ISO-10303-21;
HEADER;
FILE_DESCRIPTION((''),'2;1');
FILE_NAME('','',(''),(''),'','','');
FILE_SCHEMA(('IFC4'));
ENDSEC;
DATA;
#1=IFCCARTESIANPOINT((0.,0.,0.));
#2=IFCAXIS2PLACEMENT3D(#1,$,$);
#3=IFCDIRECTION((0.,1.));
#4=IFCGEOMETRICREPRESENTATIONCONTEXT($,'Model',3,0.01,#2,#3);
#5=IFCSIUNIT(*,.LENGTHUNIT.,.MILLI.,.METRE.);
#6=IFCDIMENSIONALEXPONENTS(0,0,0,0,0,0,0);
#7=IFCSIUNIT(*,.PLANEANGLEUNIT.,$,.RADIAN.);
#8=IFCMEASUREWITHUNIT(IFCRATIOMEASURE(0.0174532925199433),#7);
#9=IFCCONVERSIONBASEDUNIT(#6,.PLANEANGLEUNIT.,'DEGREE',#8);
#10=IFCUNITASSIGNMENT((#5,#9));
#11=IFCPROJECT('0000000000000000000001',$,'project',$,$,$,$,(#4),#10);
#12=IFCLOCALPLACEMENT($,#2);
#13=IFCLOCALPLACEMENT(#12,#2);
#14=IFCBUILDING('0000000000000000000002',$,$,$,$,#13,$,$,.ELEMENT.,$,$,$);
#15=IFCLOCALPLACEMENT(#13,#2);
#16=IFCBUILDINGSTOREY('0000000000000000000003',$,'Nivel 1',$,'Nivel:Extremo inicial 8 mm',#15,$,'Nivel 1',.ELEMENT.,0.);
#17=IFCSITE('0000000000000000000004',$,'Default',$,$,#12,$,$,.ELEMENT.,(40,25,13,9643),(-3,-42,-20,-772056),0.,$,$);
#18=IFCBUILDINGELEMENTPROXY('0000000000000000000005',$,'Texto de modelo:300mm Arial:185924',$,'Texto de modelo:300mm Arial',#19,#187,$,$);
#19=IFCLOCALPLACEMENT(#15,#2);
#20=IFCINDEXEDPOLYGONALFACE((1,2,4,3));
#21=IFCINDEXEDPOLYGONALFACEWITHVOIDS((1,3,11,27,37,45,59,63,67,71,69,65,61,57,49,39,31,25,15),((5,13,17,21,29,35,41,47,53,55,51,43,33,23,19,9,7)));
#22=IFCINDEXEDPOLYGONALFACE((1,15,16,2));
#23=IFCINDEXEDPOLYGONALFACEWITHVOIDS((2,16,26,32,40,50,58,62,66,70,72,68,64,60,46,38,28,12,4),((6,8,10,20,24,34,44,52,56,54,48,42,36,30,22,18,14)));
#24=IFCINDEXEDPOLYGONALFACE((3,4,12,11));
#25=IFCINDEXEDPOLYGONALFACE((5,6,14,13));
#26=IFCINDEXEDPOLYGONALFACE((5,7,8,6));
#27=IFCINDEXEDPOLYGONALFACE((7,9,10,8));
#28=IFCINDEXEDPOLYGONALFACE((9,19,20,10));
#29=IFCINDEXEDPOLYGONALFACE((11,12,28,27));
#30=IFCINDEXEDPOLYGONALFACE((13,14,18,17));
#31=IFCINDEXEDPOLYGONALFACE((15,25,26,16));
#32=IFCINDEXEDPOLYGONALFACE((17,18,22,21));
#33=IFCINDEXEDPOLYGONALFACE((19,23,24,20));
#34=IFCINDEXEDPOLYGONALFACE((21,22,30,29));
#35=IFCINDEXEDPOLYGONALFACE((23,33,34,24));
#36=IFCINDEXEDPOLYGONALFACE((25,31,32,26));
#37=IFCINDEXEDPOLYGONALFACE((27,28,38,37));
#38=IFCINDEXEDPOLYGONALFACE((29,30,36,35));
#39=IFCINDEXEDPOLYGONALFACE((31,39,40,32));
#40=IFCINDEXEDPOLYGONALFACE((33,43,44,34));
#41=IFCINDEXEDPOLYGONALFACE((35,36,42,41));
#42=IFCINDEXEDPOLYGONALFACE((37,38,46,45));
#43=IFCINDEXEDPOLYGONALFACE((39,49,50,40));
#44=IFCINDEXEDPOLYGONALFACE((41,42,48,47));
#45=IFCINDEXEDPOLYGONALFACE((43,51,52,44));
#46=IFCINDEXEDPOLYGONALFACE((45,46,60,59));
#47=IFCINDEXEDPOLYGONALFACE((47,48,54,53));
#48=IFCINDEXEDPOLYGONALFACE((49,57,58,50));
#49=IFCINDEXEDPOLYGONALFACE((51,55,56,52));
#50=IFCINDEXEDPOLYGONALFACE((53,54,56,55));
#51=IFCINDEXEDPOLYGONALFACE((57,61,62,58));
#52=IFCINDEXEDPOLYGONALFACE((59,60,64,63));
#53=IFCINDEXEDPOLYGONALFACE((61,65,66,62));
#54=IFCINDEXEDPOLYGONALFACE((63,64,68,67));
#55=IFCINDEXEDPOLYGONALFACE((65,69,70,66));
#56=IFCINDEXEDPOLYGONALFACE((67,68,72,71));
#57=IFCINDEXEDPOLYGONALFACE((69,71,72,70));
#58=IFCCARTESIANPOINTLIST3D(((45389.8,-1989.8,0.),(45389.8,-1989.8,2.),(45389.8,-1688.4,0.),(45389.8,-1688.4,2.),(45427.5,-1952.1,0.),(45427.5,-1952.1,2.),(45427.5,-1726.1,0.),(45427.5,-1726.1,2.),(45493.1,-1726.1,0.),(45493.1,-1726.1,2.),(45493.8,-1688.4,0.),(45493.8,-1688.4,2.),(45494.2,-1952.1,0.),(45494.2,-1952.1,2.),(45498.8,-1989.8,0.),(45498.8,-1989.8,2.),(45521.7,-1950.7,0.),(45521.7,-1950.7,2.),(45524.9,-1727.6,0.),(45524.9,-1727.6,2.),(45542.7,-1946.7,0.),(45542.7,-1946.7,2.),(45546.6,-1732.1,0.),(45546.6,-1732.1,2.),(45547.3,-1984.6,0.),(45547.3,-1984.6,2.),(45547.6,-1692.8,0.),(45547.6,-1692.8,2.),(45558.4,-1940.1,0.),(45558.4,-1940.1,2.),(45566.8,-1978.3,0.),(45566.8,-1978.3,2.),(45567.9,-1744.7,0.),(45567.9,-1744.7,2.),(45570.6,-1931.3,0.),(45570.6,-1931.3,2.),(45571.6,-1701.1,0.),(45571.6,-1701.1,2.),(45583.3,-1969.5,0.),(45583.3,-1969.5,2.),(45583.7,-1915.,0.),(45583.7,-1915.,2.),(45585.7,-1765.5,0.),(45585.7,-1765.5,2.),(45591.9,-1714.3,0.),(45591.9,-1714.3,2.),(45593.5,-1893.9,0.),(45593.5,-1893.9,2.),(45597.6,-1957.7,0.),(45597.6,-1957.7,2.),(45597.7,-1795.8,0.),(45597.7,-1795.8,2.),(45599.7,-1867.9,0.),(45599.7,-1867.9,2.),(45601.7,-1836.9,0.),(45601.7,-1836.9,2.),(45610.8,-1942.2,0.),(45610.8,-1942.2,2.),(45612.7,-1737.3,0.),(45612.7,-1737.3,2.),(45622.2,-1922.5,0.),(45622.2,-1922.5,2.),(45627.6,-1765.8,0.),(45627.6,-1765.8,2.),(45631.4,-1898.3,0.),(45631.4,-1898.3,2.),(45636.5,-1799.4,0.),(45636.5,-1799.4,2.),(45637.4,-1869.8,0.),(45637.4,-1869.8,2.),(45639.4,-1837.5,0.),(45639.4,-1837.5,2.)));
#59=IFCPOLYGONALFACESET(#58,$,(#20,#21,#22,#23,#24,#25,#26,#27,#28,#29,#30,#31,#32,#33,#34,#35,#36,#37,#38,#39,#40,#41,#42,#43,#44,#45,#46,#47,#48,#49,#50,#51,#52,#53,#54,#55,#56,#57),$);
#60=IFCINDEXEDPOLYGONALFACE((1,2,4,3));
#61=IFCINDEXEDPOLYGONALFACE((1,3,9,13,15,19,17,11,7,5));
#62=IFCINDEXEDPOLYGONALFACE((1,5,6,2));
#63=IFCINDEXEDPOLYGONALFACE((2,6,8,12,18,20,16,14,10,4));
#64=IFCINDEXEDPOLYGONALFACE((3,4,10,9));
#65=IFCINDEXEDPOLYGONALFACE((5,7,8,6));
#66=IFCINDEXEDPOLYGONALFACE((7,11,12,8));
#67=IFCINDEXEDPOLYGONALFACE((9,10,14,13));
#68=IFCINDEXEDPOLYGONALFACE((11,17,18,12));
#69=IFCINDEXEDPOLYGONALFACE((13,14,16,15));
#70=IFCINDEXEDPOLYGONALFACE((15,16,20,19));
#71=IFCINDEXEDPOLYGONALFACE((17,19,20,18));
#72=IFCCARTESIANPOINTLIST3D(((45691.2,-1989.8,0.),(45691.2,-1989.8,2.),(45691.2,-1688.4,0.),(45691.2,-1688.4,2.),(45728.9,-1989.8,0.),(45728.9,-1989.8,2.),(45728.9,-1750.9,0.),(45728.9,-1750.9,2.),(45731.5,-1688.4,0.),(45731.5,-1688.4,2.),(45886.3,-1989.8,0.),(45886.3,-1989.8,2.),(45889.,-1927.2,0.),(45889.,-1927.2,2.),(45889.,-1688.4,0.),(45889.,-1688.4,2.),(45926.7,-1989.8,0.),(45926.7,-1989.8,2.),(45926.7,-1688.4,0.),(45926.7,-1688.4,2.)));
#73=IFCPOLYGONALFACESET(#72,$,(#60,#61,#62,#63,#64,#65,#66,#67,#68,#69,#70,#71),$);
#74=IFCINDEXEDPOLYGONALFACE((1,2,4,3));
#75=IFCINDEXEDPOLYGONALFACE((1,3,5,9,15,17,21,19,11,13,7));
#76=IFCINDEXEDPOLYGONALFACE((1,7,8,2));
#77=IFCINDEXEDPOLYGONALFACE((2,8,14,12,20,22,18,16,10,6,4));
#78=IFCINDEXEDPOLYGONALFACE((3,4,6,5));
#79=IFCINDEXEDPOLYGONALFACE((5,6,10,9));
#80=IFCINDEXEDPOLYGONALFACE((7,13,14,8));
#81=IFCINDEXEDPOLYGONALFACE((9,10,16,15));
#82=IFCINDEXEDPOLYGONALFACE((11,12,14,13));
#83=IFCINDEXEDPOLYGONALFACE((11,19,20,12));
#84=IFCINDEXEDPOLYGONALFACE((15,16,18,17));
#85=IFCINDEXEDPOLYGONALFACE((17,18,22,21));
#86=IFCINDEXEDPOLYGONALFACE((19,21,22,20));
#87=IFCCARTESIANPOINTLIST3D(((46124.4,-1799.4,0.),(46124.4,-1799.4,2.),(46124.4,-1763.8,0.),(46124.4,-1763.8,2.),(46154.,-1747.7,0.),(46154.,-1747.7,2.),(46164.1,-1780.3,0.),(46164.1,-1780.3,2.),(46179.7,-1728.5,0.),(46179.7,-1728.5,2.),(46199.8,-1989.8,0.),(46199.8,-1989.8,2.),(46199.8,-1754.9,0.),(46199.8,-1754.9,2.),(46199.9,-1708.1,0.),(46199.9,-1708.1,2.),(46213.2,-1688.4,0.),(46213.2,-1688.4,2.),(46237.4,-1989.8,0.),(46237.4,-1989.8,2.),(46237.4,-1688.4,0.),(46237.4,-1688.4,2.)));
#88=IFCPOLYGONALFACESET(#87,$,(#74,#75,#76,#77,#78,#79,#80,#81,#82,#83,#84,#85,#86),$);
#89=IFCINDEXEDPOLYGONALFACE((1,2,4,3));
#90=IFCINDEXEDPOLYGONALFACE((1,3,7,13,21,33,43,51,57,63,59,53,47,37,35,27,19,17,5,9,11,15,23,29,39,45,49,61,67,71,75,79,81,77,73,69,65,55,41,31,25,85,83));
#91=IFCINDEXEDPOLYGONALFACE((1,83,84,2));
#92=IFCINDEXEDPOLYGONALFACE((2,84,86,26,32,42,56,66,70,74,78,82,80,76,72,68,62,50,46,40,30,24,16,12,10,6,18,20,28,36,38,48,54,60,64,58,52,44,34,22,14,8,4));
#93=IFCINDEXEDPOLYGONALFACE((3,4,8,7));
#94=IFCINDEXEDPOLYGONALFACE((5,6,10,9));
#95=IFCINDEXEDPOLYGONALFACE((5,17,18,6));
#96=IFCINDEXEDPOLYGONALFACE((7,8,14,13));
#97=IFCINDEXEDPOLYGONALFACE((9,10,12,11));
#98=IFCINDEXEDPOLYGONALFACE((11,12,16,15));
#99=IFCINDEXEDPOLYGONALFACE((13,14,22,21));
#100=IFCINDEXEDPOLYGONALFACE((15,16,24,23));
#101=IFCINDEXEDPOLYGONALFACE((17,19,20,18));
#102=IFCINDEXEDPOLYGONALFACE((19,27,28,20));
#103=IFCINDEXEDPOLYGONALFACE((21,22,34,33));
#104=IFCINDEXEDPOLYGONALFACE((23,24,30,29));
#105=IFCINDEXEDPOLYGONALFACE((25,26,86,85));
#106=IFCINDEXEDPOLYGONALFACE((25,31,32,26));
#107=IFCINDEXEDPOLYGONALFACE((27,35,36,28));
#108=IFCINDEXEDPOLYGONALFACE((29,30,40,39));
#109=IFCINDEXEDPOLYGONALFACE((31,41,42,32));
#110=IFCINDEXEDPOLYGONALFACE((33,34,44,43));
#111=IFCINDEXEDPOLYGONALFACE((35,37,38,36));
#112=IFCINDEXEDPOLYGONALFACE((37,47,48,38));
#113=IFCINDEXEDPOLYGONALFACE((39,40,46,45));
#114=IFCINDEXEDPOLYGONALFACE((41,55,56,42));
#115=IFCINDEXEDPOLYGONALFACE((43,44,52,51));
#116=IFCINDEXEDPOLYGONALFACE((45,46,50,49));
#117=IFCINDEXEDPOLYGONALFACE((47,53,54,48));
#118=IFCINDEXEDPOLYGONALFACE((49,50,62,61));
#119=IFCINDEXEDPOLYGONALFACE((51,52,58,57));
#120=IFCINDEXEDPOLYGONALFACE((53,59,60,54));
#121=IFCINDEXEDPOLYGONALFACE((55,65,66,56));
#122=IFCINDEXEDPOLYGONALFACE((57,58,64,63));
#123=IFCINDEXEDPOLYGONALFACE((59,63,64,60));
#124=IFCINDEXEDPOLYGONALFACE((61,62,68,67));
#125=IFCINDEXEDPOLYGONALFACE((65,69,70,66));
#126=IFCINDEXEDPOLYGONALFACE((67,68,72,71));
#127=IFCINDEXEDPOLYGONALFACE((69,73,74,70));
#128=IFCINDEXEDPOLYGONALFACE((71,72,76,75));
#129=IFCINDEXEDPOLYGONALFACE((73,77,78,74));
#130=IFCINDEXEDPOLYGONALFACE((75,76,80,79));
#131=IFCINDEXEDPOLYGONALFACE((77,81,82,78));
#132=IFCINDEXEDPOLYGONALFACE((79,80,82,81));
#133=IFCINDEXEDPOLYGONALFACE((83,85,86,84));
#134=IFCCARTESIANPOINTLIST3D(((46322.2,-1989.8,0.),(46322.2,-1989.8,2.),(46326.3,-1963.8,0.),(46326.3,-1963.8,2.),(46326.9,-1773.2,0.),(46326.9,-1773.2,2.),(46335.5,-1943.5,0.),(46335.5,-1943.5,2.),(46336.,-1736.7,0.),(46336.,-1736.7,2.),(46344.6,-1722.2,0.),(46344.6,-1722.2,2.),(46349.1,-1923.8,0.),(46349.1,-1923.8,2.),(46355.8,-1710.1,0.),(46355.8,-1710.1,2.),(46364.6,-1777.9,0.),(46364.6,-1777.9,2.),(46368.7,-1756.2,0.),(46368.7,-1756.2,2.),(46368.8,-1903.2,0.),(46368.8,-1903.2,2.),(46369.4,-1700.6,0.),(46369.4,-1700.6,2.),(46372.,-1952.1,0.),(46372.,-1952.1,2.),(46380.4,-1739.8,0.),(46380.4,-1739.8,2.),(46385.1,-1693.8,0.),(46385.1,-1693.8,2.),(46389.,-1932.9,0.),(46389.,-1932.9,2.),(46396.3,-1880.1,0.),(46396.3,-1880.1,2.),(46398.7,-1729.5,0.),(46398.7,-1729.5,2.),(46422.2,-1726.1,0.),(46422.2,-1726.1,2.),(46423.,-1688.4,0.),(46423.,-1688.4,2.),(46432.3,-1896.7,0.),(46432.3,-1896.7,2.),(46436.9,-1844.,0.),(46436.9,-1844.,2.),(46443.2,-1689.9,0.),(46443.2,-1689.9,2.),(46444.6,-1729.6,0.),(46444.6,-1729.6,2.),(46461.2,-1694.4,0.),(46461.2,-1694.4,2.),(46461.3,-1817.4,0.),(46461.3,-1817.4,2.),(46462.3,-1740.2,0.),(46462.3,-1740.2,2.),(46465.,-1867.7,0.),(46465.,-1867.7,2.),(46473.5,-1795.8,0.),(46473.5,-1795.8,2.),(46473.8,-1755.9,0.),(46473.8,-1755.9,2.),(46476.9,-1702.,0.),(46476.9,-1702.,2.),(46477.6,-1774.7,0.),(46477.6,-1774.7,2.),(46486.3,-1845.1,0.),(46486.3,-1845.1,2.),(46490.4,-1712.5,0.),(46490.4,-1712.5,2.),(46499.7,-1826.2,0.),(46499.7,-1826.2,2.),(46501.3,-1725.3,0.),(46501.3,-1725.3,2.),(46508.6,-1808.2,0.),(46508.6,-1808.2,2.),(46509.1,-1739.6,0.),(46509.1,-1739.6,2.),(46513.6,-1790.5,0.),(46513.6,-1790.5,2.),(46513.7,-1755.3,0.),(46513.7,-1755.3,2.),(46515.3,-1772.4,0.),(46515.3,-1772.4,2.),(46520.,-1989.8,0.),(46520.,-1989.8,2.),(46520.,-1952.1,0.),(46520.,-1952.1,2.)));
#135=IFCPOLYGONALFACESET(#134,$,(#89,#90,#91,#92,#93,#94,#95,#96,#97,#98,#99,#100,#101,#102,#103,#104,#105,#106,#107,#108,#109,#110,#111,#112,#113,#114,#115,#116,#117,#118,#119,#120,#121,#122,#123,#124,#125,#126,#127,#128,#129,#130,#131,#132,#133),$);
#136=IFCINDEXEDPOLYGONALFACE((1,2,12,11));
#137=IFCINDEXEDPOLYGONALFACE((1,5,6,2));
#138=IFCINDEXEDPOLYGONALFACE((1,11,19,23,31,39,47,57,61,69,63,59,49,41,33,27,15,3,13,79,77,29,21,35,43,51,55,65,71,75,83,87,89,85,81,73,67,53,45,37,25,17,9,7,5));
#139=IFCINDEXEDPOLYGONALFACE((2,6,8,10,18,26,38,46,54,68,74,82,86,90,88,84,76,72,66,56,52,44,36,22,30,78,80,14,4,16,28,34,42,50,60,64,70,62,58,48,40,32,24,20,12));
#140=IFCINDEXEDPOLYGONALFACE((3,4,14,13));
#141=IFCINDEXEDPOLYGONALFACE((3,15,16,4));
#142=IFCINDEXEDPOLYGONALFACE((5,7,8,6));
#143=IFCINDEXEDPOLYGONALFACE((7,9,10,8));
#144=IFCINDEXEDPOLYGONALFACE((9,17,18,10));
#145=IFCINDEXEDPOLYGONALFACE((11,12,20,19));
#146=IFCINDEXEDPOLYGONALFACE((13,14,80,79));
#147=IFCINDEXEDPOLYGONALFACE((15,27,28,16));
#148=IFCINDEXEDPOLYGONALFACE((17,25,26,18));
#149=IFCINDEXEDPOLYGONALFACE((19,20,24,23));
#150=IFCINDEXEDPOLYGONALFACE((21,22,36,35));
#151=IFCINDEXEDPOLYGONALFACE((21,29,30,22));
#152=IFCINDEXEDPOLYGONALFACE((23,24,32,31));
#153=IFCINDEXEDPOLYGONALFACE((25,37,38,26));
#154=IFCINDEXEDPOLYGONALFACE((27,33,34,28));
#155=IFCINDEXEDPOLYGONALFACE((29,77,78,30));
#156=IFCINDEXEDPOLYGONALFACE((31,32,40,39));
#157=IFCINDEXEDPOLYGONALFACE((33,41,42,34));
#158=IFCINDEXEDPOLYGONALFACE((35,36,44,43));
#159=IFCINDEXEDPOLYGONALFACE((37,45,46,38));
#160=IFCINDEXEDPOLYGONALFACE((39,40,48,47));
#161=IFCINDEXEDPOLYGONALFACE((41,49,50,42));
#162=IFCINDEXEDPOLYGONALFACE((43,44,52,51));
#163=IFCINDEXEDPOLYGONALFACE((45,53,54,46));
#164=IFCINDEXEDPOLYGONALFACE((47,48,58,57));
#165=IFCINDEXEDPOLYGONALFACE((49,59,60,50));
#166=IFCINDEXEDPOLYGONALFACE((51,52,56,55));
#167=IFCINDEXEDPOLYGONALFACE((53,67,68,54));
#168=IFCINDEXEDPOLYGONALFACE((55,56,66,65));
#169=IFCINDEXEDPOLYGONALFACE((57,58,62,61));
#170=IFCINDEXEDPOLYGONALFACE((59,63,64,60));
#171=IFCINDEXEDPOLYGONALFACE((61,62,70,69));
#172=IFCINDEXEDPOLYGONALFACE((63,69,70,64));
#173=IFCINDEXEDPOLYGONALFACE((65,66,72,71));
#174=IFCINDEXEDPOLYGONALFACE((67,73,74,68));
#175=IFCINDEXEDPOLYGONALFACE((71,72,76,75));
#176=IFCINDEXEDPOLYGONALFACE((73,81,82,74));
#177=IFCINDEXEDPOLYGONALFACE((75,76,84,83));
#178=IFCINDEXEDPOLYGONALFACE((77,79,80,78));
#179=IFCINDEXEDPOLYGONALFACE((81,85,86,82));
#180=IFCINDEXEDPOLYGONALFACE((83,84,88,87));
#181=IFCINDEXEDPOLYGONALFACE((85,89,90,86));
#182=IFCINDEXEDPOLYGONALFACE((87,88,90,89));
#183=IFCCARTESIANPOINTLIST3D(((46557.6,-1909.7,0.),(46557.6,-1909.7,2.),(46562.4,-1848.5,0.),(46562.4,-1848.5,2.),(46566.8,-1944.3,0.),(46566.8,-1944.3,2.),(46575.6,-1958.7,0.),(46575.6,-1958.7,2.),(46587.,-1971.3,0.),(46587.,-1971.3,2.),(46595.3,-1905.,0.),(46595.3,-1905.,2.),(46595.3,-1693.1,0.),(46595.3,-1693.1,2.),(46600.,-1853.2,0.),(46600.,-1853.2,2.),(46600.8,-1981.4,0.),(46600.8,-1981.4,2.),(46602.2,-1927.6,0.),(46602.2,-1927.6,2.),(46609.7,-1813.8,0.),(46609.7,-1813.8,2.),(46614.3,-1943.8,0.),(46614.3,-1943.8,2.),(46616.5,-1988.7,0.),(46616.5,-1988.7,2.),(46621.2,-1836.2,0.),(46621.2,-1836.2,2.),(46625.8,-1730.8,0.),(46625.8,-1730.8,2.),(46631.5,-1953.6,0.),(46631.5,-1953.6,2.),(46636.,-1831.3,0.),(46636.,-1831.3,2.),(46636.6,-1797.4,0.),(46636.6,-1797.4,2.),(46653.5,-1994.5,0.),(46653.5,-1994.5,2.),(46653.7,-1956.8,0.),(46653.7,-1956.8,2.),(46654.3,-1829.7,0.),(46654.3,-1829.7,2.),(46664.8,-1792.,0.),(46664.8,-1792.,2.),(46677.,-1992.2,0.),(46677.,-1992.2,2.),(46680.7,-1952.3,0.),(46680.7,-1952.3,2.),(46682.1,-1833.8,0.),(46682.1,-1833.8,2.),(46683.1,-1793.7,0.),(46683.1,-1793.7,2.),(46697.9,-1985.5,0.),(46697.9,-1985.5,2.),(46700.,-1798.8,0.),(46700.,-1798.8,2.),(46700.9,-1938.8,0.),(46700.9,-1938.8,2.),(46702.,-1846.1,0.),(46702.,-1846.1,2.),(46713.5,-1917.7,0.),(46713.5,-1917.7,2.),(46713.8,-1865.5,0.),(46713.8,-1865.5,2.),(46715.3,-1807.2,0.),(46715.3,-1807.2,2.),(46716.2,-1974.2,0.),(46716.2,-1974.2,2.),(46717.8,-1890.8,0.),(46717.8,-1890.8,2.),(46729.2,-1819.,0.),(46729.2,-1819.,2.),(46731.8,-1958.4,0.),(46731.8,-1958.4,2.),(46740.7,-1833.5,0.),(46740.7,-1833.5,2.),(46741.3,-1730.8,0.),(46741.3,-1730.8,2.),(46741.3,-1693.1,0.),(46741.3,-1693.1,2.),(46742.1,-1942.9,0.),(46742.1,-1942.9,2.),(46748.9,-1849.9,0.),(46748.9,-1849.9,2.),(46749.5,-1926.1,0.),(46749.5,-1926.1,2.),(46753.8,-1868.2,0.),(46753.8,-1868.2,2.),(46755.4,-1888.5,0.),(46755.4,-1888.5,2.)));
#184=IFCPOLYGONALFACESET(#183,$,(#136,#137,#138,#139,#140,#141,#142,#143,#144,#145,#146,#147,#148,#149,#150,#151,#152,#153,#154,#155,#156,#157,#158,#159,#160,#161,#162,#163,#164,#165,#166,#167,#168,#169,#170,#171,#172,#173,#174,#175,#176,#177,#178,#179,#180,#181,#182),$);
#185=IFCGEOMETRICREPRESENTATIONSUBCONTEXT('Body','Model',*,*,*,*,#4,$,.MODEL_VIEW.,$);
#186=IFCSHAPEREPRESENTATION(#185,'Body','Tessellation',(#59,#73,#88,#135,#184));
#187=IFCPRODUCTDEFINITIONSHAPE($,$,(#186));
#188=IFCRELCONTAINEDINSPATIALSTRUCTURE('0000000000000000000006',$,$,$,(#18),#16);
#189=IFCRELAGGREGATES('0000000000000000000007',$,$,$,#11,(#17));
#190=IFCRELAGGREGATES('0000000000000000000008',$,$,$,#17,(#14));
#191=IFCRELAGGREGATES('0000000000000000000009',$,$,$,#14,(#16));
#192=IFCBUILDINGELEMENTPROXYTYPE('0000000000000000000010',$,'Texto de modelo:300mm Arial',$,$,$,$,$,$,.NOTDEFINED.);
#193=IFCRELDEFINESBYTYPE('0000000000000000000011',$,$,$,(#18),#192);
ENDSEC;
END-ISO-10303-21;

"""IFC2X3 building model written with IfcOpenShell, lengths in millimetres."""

from ifc_helpers import new_model, entity, si_unit, converted_unit, direction, frame, origin, place, context, subcontext, project, spatial, polyline, outline, extrude, type_object, element, save


model = new_model("IFC2X3")

# Units and contexts
model_context = context("Model", 3, precision=0.01, world=origin(), true_north=direction((0.0, 1.0)))
body_context = subcontext(model_context, "Body", "Model", "MODEL_VIEW")
ifc_project = project(units=[si_unit("LENGTHUNIT", "METRE", prefix="MILLI"), converted_unit("PLANEANGLEUNIT", "DEGREE", entity("IfcRatioMeasure", 0.0174532925199433), si_unit("PLANEANGLEUNIT", "RADIAN"), dimensions=[0, 0, 0, 0, 0, 0, 0])], contexts=[model_context])

# Site, building, storey
site_placement = place(None, origin())
site = spatial("IfcSite", under=ifc_project, at=site_placement, Name="Default", CompositionType="ELEMENT", RefLatitude=(40, 25, 13, 9643), RefLongitude=(-3, -42, -20, -772056), RefElevation=0.0)
building_placement = place(site_placement, origin())
building = spatial("IfcBuilding", under=site, at=building_placement, CompositionType="ELEMENT")
storey_placement = place(building_placement, origin())
storey = spatial("IfcBuildingStorey", under=building, at=storey_placement, Name="Nivel 1", ObjectType="Nivel:Extremo inicial 8 mm", LongName="Nivel 1", CompositionType="ELEMENT", Elevation=0.0)

# Building element proxy
building_element_proxy_type_1 = type_object("IfcBuildingElementProxyType", Name="Texto de modelo:300mm Arial", PredefinedType="NOTDEFINED")
proxy_1_placement = place(storey_placement, frame((45389.8, -1994.5, 0.0)))
element("IfcBuildingElementProxy", 1, at=proxy_1_placement, inside=storey, type_object=building_element_proxy_type_1, Name="Texto de modelo:300mm Arial:185924", ObjectType="Texto de modelo:300mm Arial", context=body_context, shape_type="SweptSolid", body=[
    extrude(outline(polyline([(-178.4, -141.0), (-69.4, -141.0), (-21.0, -135.8), (-1.4, -129.5), (15.0, -120.7), (29.4, -108.9), (42.6, -93.4), (54.0, -73.7), (63.2, -49.5), (69.2, -21.0), (71.2, 11.3), (68.2, 49.4), (59.3, 83.0), (44.5, 111.5), (23.7, 134.5), (3.4, 147.7), (-20.6, 156.1), (-74.4, 160.4), (-178.4, 160.4), (-178.4, -141.0)]), holes=[polyline([(-140.7, -103.3), (-140.7, 122.7), (-75.1, 122.7), (-43.3, 121.2), (-21.7, 116.7), (-0.4, 104.1), (17.4, 83.3), (29.5, 53.0), (33.5, 11.9), (31.5, -19.1), (25.3, -45.1), (15.5, -66.2), (2.4, -82.5), (-9.8, -91.3), (-25.6, -97.9), (-46.5, -101.9), (-74.1, -103.3), (-140.7, -103.3)])]), frame((178.4, 145.7, 0.0)), (0.0, 0.0, 1.0), 2.0),
    extrude(outline(polyline([(-117.7, -150.7), (-80.1, -150.7), (-80.1, 88.1), (77.4, -150.7), (117.7, -150.7), (117.7, 150.7), (80.1, 150.7), (80.1, -88.1), (-77.4, 150.7), (-117.7, 150.7), (-117.7, -150.7)])), frame((419.1, 155.4, 0.0)), (0.0, 0.0, 1.0), 2.0),
    extrude(outline(polyline([(-204.4, -52.5), (97.0, -52.5), (97.0, -28.2), (77.2, -14.9), (56.9, 5.3), (37.7, 30.9), (21.6, 60.5), (-14.0, 60.5), (5.0, 20.8), (30.4, -14.9), (-204.4, -14.9), (-204.4, -52.5)])), frame((795.1, 209.1, 0.0), z_axis=(0.0, 0.0, 1.0), x_axis=(0.0, 1.0, 0.0)), (0.0, 0.0, 1.0), 2.0),
    extrude(outline(polyline([(-91.6, -150.5), (-91.6, -188.2), (106.2, -188.2), (102.1, -162.2), (92.9, -141.9), (79.3, -122.2), (59.6, -101.6), (32.1, -78.5), (-8.5, -42.4), (-32.9, -15.8), (-45.1, 5.8), (-49.2, 26.9), (-45.4, 45.8), (-33.9, 61.4), (-16.2, 72.0), (6.2, 75.5), (29.7, 72.1), (48.0, 61.8), (59.7, 45.4), (63.8, 23.7), (101.5, 28.4), (92.4, 64.9), (83.8, 79.4), (72.6, 91.5), (59.0, 101.0), (43.3, 107.8), (5.4, 113.2), (-14.8, 111.7), (-32.8, 107.2), (-48.5, 99.6), (-62.0, 89.1), (-72.9, 76.3), (-80.7, 62.0), (-85.3, 46.3), (-86.9, 29.2), (-85.2, 11.2), (-80.2, -6.5), (-71.3, -24.6), (-57.9, -43.5), (-36.6, -66.1), (-3.9, -95.1), (39.4, -131.3), (56.4, -150.5), (-91.6, -150.5)])), frame((1038.6, 192.9, 0.0), z_axis=(0.0, 0.0, -1.0), x_axis=(-1.0, 0.0, 0.0)), (0.0, 0.0, -1.0), 2.0),
    extrude(outline(polyline([(1.4, -113.1), (37.2, -113.1), (53.4, -108.4), (68.5, -100.5), (81.8, -89.8), (92.9, -76.5), (108.0, -42.2), (111.8, -18.9), (110.6, 3.0), (104.4, 23.5), (93.2, 42.7), (80.9, 56.7), (66.6, 68.1), (31.7, 83.5), (11.7, 87.1), (-7.3, 87.1), (-25.2, 83.4), (-42.2, 76.0), (-57.1, 65.7), (-69.2, 53.0), (-78.5, 38.0), (-84.8, 20.7), (-86.8, -7.9), (-77.9, -38.1), (-154.0, -1.2), (-124.3, 110.4), (-160.7, 120.1), (-198.2, -21.0), (-56.5, -92.8), (-42.3, -57.6), (-53.3, -32.8), (-54.2, -17.2), (-51.1, 0.9), (-40.0, 26.8), (-23.0, 42.8), (-1.2, 49.2), (24.3, 46.5), (49.2, 35.5), (66.3, 17.9), (74.2, -5.1), (71.6, -32.4), (62.8, -53.0), (48.9, -67.1), (30.2, -74.6), (6.6, -75.5), (1.4, -113.1)])), frame((1276.7, 115.2, 0.0), z_axis=(0.0, 0.0, 1.0), x_axis=(0.256974, -0.966418, 0.0)), (0.0, 0.0, 1.0), 2.0),
])

save(model, "model.ifc")
